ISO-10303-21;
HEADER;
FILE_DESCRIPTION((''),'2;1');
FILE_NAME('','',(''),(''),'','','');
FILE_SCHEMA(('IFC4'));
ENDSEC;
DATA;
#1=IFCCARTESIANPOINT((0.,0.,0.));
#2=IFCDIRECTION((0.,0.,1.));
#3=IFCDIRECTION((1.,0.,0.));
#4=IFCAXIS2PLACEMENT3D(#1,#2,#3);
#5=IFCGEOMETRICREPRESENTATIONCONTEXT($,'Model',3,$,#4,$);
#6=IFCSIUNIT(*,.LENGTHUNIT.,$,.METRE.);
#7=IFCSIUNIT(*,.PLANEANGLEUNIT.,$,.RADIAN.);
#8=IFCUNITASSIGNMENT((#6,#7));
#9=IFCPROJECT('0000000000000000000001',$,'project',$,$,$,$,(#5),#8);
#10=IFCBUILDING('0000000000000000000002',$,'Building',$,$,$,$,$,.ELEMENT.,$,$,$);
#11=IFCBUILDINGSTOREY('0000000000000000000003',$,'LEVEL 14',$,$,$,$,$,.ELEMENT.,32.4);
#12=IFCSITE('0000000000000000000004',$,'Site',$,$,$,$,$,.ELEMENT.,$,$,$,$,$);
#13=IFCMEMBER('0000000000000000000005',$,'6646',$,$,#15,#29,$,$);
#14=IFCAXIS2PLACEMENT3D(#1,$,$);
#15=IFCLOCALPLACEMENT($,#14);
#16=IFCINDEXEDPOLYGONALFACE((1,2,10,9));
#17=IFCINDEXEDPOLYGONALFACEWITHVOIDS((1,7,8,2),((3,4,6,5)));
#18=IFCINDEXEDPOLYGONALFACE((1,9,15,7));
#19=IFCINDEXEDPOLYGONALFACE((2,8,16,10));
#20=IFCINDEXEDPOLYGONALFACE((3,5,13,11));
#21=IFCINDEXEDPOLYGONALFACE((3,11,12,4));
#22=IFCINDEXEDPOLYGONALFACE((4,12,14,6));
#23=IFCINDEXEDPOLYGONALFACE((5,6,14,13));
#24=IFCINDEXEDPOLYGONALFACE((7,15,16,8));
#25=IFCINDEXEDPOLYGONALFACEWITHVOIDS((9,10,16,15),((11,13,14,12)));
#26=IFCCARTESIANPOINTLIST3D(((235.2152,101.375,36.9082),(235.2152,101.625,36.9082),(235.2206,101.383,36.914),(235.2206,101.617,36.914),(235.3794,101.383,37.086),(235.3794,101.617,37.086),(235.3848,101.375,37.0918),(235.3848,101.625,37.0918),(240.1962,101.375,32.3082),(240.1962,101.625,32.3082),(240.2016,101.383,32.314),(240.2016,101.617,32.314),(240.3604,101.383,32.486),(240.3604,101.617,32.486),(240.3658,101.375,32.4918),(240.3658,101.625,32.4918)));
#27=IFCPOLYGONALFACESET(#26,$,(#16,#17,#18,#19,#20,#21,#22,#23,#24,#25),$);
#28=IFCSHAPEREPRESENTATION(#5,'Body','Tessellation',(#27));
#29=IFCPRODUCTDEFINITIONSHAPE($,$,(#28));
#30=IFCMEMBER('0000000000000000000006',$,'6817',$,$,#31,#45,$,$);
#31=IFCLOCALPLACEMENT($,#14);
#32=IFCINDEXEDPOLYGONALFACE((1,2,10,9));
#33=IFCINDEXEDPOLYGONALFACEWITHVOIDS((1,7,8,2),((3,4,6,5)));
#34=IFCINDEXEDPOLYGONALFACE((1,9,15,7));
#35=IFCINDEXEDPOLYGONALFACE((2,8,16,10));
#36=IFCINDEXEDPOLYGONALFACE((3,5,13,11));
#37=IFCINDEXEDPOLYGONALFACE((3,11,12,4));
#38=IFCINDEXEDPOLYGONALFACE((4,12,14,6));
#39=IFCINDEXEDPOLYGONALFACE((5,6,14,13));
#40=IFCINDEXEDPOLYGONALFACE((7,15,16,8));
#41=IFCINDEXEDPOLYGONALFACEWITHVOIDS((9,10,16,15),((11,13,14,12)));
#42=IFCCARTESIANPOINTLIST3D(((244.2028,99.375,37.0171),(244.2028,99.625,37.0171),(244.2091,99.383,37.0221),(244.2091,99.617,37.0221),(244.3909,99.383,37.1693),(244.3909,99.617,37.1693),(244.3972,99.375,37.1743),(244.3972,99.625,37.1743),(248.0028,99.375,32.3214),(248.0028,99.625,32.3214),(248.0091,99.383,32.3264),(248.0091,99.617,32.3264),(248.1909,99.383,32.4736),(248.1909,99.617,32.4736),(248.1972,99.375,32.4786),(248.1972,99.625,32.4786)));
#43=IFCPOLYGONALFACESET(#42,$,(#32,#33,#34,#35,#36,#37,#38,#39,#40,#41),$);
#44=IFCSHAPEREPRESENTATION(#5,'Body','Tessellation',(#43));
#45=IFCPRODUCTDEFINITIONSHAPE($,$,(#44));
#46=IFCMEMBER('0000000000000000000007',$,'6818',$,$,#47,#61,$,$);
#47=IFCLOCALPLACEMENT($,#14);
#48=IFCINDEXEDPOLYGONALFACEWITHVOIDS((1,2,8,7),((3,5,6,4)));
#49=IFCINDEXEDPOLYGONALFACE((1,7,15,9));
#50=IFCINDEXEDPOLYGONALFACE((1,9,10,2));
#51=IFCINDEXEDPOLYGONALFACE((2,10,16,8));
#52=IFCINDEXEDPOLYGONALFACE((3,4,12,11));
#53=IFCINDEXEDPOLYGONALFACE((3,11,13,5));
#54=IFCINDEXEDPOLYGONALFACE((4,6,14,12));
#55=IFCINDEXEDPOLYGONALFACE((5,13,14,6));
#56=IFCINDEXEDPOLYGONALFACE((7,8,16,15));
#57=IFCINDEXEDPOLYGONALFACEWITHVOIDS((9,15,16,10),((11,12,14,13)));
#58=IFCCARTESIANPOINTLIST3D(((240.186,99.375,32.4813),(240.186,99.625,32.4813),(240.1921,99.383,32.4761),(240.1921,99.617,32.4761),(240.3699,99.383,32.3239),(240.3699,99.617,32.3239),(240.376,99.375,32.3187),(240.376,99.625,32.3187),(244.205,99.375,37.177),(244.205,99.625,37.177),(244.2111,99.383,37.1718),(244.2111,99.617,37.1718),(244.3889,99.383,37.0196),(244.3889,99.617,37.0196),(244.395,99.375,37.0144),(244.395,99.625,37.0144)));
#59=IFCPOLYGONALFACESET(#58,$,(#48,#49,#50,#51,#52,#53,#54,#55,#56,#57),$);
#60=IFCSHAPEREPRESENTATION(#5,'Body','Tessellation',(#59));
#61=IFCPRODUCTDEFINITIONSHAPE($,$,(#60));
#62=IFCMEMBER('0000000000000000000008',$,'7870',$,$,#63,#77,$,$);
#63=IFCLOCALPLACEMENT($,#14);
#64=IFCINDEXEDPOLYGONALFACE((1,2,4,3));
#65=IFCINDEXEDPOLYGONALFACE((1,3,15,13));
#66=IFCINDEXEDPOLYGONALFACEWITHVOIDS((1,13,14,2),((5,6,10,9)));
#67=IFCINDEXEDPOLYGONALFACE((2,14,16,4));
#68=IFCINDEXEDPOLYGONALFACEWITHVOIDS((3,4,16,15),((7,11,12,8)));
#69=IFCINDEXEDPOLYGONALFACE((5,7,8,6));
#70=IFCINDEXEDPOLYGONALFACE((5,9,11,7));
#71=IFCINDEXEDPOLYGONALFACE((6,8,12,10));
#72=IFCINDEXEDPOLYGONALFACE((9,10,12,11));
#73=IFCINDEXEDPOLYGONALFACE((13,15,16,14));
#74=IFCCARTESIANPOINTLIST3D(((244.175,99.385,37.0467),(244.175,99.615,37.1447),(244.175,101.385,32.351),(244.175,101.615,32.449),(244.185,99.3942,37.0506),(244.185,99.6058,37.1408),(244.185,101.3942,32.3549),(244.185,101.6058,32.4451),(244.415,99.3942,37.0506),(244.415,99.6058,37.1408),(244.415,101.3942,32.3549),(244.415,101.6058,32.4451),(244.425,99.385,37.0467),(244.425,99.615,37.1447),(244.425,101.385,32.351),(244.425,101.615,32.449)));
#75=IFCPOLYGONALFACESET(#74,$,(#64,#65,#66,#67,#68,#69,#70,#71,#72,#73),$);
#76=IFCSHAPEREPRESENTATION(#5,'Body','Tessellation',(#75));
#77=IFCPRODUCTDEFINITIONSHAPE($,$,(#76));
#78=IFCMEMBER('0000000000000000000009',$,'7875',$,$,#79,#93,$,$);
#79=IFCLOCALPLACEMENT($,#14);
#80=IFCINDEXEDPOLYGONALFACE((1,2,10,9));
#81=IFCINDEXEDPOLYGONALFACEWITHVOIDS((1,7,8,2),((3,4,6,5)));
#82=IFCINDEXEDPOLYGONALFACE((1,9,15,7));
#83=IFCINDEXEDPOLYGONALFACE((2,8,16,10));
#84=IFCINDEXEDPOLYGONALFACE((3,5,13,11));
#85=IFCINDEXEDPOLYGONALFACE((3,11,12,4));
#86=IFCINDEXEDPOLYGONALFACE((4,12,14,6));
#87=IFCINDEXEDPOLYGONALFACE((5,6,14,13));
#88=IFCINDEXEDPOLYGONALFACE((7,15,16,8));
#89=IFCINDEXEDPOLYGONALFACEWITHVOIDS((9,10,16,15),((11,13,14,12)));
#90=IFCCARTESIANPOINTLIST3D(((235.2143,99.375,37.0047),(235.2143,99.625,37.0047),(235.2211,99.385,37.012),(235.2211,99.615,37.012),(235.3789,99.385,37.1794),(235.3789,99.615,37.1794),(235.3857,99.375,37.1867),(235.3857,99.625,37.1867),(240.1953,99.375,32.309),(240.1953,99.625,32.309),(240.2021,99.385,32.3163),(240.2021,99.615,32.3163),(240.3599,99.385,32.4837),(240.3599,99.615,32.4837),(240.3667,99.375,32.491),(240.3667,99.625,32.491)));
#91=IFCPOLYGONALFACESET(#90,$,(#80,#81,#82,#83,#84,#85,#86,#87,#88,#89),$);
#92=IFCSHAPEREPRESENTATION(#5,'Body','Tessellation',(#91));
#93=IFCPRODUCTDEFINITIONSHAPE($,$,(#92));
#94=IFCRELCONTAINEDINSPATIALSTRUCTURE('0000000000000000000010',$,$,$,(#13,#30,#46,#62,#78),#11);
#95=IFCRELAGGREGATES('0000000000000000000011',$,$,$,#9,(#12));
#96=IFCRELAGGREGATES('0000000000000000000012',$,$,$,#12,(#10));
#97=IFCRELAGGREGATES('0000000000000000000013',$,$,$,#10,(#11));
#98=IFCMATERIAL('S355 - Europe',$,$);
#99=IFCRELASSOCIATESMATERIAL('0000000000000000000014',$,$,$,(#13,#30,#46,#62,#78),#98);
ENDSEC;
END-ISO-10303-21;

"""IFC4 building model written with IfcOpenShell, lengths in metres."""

from ifc_helpers import new_model, si_unit, frame, origin_with_axes, origin_2d_with_axis, place, context, project, spatial, hollow_rectangle, extrude, material, material_profile, profile_set, profile_usage, element, save


model = new_model("IFC4")

# Units and contexts
model_context = context("Model", 3, world=origin_with_axes())
ifc_project = project(units=[si_unit("LENGTHUNIT", "METRE"), si_unit("PLANEANGLEUNIT", "RADIAN")], contexts=[model_context])

# Site, building, storey
site = spatial("IfcSite", under=ifc_project, Name="Site", CompositionType="ELEMENT")
building = spatial("IfcBuilding", under=site, Name="Building", CompositionType="ELEMENT")
storey = spatial("IfcBuildingStorey", under=building, Name="LEVEL 14", CompositionType="ELEMENT", Elevation=32.4)

# Shared definitions
ifc_material = material(Name="S355 - Europe")

# Members
ifc_material_profile_1 = material_profile(ifc_material, hollow_rectangle(XDim=0.25, YDim=0.25, WallThickness=0.008, at=origin_2d_with_axis()))
ifc_profile_set_1 = profile_set([ifc_material_profile_1])
ifc_profile_usage_1 = profile_usage(ifc_profile_set_1, cardinal=10)
member_1_placement = place(None, frame((240.281, 101.5, 32.4), z_axis=(-0.734645, 0.0, 0.678452), x_axis=(0.0, -1.0, 0.0)))
element("IfcMember", 1, at=member_1_placement, inside=storey, material=ifc_profile_usage_1, Name="6646", context=model_context, shape_type="SweptSolid", body=[
    extrude(hollow_rectangle(XDim=0.25, YDim=0.25, WallThickness=0.008, at=origin_2d_with_axis()), origin_with_axes(), (0.0, 0.0, 1.0), 6.7801),
])
ifc_material_profile_2 = material_profile(ifc_material, hollow_rectangle(XDim=0.25, YDim=0.25, WallThickness=0.008, at=origin_2d_with_axis()))
ifc_profile_set_2 = profile_set([ifc_material_profile_2])
ifc_profile_usage_2 = profile_usage(ifc_profile_set_2, cardinal=10)
member_2_placement = place(None, frame((248.1, 99.5, 32.4), z_axis=(-0.62907, 0.0, 0.777349), x_axis=(0.0, -1.0, 0.0)))
element("IfcMember", 2, at=member_2_placement, inside=storey, material=ifc_profile_usage_2, Name="6817", context=model_context, shape_type="SweptSolid", body=[
    extrude(hollow_rectangle(XDim=0.25, YDim=0.25, WallThickness=0.008, at=origin_2d_with_axis()), origin_with_axes(), (0.0, 0.0, 1.0), 6.0407),
])
ifc_material_profile_3 = material_profile(ifc_material, hollow_rectangle(XDim=0.25, YDim=0.25, WallThickness=0.008, at=origin_2d_with_axis()))
ifc_profile_set_3 = profile_set([ifc_material_profile_3])
ifc_profile_usage_3 = profile_usage(ifc_profile_set_3, cardinal=10)
member_3_placement = place(None, frame((244.3, 99.5, 37.0957), z_axis=(-0.650242, 0.0, -0.759727), x_axis=(0.0, -1.0, 0.0)))
element("IfcMember", 3, at=member_3_placement, inside=storey, material=ifc_profile_usage_3, Name="6818", context=model_context, shape_type="SweptSolid", body=[
    extrude(hollow_rectangle(XDim=0.25, YDim=0.25, WallThickness=0.008, at=origin_2d_with_axis()), origin_with_axes(), (0.0, 0.0, 1.0), 6.1808),
])
ifc_material_profile_4 = material_profile(ifc_material, hollow_rectangle(XDim=0.25, YDim=0.25, WallThickness=0.01, at=origin_2d_with_axis()))
ifc_profile_set_4 = profile_set([ifc_material_profile_4])
ifc_profile_usage_4 = profile_usage(ifc_profile_set_4, cardinal=10)
member_4_placement = place(None, frame((244.3, 99.5, 37.0957), z_axis=(0.0, 0.391859, -0.920025), x_axis=(-1.0, 0.0, 0.0)))
element("IfcMember", 4, at=member_4_placement, inside=storey, material=ifc_profile_usage_4, Name="7870", context=model_context, shape_type="SweptSolid", body=[
    extrude(hollow_rectangle(XDim=0.25, YDim=0.25, WallThickness=0.01, at=origin_2d_with_axis()), origin_with_axes(), (0.0, 0.0, 1.0), 5.1039),
])
ifc_material_profile_5 = material_profile(ifc_material, hollow_rectangle(XDim=0.25, YDim=0.25, WallThickness=0.01, at=origin_2d_with_axis()))
ifc_profile_set_5 = profile_set([ifc_material_profile_5])
ifc_profile_usage_5 = profile_usage(ifc_profile_set_5, cardinal=10)
member_5_placement = place(None, frame((240.281, 99.5, 32.4), z_axis=(-0.727638, 0.0, 0.685961), x_axis=(0.0, -1.0, 0.0)))
element("IfcMember", 5, at=member_5_placement, inside=storey, material=ifc_profile_usage_5, Name="7875", context=model_context, shape_type="SweptSolid", body=[
    extrude(hollow_rectangle(XDim=0.25, YDim=0.25, WallThickness=0.01, at=origin_2d_with_axis()), origin_with_axes(), (0.0, 0.0, 1.0), 6.8454),
])

save(model, "model.ifc")
